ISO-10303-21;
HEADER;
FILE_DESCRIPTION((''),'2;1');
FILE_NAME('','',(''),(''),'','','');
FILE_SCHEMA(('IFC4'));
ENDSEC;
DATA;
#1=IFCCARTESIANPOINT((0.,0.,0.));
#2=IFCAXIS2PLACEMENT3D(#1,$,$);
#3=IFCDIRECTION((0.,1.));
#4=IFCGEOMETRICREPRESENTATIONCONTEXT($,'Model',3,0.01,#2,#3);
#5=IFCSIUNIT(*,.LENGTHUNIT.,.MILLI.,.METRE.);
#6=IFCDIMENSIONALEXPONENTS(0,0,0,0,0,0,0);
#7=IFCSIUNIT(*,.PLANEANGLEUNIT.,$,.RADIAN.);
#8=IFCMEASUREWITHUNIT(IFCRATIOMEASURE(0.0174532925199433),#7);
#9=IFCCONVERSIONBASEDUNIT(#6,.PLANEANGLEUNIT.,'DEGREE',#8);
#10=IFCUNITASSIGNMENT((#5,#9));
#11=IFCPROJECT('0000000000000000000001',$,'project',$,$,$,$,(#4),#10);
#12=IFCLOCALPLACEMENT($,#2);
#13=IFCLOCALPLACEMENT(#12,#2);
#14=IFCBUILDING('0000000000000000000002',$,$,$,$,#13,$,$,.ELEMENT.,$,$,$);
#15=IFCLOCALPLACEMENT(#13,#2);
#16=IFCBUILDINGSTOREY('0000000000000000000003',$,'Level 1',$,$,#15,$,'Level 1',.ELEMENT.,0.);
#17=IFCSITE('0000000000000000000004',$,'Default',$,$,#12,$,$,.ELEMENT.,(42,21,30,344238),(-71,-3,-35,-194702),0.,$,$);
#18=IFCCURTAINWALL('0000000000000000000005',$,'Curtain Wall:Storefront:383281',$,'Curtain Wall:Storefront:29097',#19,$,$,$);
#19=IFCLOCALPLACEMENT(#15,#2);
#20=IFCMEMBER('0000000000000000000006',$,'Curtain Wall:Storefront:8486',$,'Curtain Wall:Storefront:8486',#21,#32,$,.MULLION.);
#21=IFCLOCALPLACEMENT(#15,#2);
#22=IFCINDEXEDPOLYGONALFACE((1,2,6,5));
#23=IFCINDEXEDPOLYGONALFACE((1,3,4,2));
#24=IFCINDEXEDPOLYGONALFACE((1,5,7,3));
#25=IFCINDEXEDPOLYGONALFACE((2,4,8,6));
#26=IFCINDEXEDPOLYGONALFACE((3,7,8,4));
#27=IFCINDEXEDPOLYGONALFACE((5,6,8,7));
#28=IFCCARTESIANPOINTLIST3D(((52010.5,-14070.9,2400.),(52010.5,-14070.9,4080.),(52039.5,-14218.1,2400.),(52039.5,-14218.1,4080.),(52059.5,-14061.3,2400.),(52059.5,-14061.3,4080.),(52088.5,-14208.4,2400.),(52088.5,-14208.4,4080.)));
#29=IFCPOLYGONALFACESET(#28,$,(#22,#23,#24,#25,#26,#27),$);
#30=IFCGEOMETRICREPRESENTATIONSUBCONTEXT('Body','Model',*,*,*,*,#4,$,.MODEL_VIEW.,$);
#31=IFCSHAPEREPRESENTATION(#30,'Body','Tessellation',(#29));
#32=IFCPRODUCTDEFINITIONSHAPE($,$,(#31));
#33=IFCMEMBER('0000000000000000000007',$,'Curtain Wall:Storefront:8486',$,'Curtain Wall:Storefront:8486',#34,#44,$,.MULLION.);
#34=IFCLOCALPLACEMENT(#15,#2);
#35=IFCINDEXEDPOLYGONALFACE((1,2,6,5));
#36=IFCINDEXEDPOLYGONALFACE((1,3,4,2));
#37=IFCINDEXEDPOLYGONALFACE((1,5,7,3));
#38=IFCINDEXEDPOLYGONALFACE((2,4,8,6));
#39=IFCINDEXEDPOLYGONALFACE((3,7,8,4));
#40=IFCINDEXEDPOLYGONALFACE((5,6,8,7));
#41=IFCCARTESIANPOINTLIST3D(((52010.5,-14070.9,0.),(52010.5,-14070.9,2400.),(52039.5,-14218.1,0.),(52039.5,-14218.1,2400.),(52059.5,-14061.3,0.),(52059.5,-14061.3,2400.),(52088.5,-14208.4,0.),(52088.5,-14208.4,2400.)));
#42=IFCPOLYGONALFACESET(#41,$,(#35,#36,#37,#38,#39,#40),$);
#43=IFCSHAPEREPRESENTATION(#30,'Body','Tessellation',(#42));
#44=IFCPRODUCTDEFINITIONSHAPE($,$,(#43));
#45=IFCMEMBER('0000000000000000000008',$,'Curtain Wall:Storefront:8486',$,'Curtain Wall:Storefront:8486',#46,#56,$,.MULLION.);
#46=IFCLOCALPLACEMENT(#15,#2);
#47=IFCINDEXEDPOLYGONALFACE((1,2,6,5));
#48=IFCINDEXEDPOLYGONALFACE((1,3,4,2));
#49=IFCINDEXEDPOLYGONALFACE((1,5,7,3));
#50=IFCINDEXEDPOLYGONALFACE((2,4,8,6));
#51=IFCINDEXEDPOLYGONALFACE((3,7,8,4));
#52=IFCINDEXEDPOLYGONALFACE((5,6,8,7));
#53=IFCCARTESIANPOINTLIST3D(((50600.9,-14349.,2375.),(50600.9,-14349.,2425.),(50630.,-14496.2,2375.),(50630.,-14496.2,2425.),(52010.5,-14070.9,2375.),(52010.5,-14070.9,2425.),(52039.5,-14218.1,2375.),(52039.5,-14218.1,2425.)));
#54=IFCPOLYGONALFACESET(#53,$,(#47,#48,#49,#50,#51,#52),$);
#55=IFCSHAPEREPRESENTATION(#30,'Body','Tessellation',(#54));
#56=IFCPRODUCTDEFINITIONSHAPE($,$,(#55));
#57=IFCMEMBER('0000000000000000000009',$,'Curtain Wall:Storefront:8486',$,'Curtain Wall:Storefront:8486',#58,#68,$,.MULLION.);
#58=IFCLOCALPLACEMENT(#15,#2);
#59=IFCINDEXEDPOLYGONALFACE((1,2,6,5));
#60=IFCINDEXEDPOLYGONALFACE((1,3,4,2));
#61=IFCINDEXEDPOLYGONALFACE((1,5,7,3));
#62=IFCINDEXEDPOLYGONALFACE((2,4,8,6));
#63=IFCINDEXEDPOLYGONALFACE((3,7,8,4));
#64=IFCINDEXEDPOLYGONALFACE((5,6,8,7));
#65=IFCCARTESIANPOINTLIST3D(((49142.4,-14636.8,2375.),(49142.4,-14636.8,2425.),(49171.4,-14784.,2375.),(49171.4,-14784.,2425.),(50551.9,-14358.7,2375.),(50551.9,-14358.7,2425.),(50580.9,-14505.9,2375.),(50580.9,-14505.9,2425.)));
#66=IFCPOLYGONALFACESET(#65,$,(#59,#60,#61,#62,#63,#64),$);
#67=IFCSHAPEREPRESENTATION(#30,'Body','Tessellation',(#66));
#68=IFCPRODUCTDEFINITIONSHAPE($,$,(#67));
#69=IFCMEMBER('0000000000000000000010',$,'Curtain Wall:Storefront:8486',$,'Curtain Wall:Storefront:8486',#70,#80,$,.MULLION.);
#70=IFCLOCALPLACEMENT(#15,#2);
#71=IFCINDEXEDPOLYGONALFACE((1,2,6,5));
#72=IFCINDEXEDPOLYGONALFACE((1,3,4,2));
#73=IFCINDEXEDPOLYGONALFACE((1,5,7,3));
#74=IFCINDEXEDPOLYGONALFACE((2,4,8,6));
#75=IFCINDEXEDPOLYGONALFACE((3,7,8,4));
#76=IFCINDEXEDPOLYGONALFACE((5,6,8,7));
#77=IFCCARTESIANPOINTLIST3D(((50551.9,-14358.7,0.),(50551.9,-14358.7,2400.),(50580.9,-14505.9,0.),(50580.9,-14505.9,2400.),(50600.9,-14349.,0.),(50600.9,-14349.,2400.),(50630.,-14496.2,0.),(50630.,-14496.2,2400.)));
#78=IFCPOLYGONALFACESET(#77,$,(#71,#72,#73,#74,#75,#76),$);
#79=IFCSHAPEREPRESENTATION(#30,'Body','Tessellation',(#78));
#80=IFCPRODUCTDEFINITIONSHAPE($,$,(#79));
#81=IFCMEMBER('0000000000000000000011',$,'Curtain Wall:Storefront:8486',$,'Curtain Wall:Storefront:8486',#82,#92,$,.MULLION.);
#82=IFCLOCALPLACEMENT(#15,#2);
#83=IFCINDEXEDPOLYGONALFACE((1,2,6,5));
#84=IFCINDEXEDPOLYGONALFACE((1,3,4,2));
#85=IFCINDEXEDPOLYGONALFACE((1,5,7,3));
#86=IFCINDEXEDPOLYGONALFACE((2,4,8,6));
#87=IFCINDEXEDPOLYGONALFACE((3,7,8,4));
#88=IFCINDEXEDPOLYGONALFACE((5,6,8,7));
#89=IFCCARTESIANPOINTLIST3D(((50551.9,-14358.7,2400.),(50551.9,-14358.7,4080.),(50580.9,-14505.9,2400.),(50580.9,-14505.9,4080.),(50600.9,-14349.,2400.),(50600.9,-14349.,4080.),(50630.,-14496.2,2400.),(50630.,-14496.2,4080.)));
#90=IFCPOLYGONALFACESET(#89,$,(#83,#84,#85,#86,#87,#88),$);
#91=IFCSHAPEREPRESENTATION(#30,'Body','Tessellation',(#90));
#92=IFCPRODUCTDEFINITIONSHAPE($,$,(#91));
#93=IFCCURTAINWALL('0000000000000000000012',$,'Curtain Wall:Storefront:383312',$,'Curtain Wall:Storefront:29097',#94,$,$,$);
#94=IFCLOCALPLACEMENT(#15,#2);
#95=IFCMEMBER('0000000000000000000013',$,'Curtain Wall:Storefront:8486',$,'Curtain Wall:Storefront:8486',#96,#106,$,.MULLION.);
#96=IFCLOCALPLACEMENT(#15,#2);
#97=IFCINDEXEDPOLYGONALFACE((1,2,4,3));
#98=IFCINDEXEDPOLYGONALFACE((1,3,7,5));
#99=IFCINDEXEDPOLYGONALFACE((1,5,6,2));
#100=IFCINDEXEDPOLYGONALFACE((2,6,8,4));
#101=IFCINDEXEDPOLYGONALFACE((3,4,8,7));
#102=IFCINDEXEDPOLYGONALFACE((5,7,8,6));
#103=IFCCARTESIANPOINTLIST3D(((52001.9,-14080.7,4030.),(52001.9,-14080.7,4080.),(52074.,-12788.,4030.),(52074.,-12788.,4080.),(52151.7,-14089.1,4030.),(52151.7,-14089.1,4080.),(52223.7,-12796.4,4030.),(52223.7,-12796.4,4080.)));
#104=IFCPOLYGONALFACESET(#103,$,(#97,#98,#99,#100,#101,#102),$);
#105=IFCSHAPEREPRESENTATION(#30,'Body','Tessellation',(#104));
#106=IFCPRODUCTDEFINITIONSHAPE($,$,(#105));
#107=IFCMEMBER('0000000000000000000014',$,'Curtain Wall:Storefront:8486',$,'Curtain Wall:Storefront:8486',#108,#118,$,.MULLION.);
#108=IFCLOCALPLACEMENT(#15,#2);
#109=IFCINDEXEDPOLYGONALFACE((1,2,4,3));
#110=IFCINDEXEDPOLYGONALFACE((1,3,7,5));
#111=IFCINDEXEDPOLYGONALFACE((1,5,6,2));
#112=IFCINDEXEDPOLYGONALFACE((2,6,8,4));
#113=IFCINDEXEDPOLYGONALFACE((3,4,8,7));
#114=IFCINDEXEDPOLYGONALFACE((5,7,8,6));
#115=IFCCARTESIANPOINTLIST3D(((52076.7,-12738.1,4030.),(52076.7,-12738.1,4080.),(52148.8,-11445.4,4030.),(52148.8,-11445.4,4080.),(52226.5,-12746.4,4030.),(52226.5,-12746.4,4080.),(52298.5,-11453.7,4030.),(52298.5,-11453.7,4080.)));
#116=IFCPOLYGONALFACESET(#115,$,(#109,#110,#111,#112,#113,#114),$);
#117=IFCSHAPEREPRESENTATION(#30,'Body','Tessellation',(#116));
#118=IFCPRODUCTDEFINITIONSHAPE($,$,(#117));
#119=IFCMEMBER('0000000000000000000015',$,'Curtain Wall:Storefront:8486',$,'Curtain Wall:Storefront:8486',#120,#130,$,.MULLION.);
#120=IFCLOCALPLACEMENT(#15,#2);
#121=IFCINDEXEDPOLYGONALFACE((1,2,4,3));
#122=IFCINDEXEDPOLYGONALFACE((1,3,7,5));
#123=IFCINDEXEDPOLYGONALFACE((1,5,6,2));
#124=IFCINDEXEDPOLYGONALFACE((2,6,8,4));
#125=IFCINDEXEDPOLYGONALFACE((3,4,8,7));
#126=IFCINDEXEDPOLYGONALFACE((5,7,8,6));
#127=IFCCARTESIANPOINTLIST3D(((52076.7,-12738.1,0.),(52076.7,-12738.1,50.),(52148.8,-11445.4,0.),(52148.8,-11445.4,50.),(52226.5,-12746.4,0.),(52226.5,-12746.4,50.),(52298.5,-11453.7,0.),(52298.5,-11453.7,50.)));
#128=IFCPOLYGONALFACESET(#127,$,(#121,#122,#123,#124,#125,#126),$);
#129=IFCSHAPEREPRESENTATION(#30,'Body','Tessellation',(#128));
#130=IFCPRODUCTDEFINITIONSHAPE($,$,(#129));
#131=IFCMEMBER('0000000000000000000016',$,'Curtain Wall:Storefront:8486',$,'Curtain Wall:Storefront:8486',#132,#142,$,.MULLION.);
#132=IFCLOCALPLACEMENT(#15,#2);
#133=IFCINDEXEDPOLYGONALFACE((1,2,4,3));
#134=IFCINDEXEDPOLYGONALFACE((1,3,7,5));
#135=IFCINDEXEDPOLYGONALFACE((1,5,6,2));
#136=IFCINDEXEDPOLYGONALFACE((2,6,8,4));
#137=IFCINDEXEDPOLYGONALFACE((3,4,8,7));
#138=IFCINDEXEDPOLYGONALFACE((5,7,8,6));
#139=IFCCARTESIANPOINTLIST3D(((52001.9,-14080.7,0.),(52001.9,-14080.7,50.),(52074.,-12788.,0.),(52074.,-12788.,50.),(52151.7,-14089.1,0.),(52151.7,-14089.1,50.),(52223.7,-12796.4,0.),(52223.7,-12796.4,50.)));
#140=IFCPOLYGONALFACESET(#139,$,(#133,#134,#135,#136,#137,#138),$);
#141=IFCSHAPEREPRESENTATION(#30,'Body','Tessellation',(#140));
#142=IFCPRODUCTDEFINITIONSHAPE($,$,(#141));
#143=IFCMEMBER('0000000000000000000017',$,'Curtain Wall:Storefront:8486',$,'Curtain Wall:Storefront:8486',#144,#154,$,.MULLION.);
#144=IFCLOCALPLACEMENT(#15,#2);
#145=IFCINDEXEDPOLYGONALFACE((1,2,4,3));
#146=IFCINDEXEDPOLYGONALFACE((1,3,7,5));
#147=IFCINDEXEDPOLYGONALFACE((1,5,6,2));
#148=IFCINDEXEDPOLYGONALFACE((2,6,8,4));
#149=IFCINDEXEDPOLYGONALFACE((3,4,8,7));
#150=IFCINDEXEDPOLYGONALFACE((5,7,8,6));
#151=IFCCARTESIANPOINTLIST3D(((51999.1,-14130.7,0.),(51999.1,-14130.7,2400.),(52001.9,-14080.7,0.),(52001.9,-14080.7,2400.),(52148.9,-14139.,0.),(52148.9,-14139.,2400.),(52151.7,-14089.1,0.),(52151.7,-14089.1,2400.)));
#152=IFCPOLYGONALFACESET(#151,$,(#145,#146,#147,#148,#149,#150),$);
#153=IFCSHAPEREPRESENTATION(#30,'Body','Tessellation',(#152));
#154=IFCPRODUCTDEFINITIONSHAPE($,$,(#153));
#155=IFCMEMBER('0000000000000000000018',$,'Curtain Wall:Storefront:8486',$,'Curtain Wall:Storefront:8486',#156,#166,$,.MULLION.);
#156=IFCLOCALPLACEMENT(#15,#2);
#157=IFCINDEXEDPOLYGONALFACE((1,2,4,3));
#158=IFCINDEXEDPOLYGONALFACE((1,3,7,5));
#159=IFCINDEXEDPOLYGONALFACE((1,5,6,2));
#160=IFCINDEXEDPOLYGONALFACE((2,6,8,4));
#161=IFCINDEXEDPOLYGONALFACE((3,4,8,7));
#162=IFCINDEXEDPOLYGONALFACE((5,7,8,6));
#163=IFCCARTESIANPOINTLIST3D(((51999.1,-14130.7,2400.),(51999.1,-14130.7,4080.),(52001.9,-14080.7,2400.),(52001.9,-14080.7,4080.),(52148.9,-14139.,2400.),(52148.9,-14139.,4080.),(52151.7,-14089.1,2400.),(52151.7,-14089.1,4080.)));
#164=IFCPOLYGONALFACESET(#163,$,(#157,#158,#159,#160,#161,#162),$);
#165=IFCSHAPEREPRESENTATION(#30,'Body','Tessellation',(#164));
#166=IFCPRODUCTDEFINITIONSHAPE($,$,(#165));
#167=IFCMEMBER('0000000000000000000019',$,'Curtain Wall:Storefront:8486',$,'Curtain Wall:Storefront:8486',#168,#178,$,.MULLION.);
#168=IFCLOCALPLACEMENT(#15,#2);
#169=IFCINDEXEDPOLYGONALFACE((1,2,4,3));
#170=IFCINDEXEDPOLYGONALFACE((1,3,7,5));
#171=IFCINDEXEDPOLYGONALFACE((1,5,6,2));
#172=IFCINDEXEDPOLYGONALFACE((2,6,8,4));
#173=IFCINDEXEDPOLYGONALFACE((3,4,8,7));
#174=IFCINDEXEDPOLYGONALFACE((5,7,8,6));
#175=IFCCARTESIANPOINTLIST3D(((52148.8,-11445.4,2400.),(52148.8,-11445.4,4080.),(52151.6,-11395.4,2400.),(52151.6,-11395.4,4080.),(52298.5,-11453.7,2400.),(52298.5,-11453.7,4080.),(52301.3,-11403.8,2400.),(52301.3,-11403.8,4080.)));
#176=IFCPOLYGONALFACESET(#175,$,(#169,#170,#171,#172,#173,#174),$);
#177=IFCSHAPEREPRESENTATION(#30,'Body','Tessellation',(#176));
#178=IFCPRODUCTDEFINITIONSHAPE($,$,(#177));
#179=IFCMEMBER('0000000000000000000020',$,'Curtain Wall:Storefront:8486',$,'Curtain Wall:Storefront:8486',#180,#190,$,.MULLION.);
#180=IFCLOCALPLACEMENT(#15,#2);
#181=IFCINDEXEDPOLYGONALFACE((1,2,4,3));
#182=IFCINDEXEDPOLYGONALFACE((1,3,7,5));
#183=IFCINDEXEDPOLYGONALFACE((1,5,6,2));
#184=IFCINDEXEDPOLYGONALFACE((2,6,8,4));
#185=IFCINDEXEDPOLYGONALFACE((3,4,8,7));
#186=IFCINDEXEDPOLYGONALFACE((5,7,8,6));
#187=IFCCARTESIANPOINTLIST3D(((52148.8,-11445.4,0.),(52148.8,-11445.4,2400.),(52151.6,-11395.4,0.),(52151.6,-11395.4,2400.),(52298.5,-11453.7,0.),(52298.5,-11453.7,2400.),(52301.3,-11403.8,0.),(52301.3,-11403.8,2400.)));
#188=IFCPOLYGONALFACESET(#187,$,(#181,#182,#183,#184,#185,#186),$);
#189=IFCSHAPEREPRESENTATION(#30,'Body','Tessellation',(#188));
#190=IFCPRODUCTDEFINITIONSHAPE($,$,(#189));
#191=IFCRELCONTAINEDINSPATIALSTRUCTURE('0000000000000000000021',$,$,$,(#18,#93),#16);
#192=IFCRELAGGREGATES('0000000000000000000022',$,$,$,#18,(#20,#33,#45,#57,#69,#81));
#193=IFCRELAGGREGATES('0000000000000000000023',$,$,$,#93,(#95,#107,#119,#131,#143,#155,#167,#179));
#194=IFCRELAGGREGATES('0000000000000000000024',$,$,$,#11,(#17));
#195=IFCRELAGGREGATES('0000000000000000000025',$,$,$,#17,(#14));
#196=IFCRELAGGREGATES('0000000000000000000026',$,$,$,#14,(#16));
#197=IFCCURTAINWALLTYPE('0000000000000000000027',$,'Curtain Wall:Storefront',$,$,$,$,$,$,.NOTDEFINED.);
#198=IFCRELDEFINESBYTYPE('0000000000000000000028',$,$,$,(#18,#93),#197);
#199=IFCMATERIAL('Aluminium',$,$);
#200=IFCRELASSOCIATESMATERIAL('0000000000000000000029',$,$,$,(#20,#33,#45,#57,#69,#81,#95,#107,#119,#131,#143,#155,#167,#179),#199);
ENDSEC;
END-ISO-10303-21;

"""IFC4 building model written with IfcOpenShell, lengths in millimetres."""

from ifc_helpers import new_model, entity, si_unit, converted_unit, direction, frame, frame_2d, origin, origin_2d_with_axis, place, context, subcontext, project, spatial, rectangle, extrude, material, type_object, element, aggregate, save


model = new_model("IFC4")

# Units and contexts
model_context = context("Model", 3, precision=0.01, world=origin(), true_north=direction((0.0, 1.0)))
body_context = subcontext(model_context, "Body", "Model", "MODEL_VIEW")
ifc_project = project(units=[si_unit("LENGTHUNIT", "METRE", prefix="MILLI"), converted_unit("PLANEANGLEUNIT", "DEGREE", entity("IfcRatioMeasure", 0.0174532925199433), si_unit("PLANEANGLEUNIT", "RADIAN"), dimensions=[0, 0, 0, 0, 0, 0, 0])], contexts=[model_context])

# Site, building, storey
site_placement = place(None, origin())
site = spatial("IfcSite", under=ifc_project, at=site_placement, Name="Default", CompositionType="ELEMENT", RefLatitude=(42, 21, 30, 344238), RefLongitude=(-71, -3, -35, -194702), RefElevation=0.0)
building_placement = place(site_placement, origin())
building = spatial("IfcBuilding", under=site, at=building_placement, CompositionType="ELEMENT")
storey_placement = place(building_placement, origin())
storey = spatial("IfcBuildingStorey", under=building, at=storey_placement, Name="Level 1", LongName="Level 1", CompositionType="ELEMENT", Elevation=0.0)

# Curtain walls, members
curtain_wall_type = type_object("IfcCurtainWallType", Name="Curtain Wall:Storefront", PredefinedType="NOTDEFINED")
curtain_wall_1_placement = place(storey_placement, origin())
curtain_wall_1 = element("IfcCurtainWall", 1, at=curtain_wall_1_placement, inside=storey, type_object=curtain_wall_type, Name="Curtain Wall:Storefront:383281", ObjectType="Curtain Wall:Storefront:29097")
ifc_material = material(Name="Aluminium")
member_1_placement = place(curtain_wall_1_placement, origin())
member_1 = element("IfcMember", 2, at=member_1_placement, material=ifc_material, Name="Curtain Wall:Storefront:8486", ObjectType="Curtain Wall:Storefront:8486", PredefinedType="MULLION", context=body_context, shape_type="SweptSolid", body=[
    extrude(rectangle(XDim=50.0, YDim=150.0, at=frame_2d((0.0, 0.0), x_axis=(1.0, 0.0))), frame((52049.5, -14139.7, 4080.0), z_axis=(0.0, 0.0, -1.0), x_axis=(0.981087, 0.193568, 0.0)), (0.0, 0.0, 1.0), 1680.0),
])
member_2_placement = place(curtain_wall_1_placement, origin())
member_2 = element("IfcMember", 3, at=member_2_placement, material=ifc_material, Name="Curtain Wall:Storefront:8486", ObjectType="Curtain Wall:Storefront:8486", PredefinedType="MULLION", context=body_context, shape_type="SweptSolid", body=[
    extrude(rectangle(XDim=50.0, YDim=150.0, at=frame_2d((0.0, 0.0), x_axis=(1.0, 0.0))), frame((52049.5, -14139.7, 2400.0), z_axis=(0.0, 0.0, -1.0), x_axis=(0.981087, 0.193568, 0.0)), (0.0, 0.0, 1.0), 2400.0),
])
member_3_placement = place(curtain_wall_1_placement, origin())
member_3 = element("IfcMember", 4, at=member_3_placement, material=ifc_material, Name="Curtain Wall:Storefront:8486", ObjectType="Curtain Wall:Storefront:8486", PredefinedType="MULLION", context=body_context, shape_type="SweptSolid", body=[
    extrude(rectangle(XDim=50.0, YDim=150.0, at=frame_2d((0.0, 0.0), x_axis=(1.0, 0.0))), frame((50615.5, -14422.6, 2400.0), z_axis=(0.981087, 0.193568, 0.0), x_axis=(0.0, 0.0, -1.0)), (0.0, 0.0, 1.0), 1436.7),
])
member_4_placement = place(curtain_wall_1_placement, origin())
member_4 = element("IfcMember", 5, at=member_4_placement, material=ifc_material, Name="Curtain Wall:Storefront:8486", ObjectType="Curtain Wall:Storefront:8486", PredefinedType="MULLION", context=body_context, shape_type="SweptSolid", body=[
    extrude(rectangle(XDim=50.0, YDim=150.0, at=frame_2d((0.0, 0.0), x_axis=(1.0, 0.0))), frame((49156.9, -14710.4, 2400.0), z_axis=(0.981087, 0.193568, 0.0), x_axis=(0.0, 0.0, -1.0)), (0.0, 0.0, 1.0), 1436.7),
])
member_5_placement = place(curtain_wall_1_placement, origin())
member_5 = element("IfcMember", 6, at=member_5_placement, material=ifc_material, Name="Curtain Wall:Storefront:8486", ObjectType="Curtain Wall:Storefront:8486", PredefinedType="MULLION", context=body_context, shape_type="SweptSolid", body=[
    extrude(rectangle(XDim=150.0, YDim=50.0, at=origin_2d_with_axis()), frame((50590.9, -14427.5, 0.0), z_axis=(0.0, 0.0, 1.0), x_axis=(-0.193568, 0.981087, 0.0)), (0.0, 0.0, 1.0), 2400.0),
])
member_6_placement = place(curtain_wall_1_placement, origin())
member_6 = element("IfcMember", 7, at=member_6_placement, material=ifc_material, Name="Curtain Wall:Storefront:8486", ObjectType="Curtain Wall:Storefront:8486", PredefinedType="MULLION", context=body_context, shape_type="SweptSolid", body=[
    extrude(rectangle(XDim=150.0, YDim=50.0, at=origin_2d_with_axis()), frame((50590.9, -14427.5, 2400.0), z_axis=(0.0, 0.0, 1.0), x_axis=(-0.193568, 0.981087, 0.0)), (0.0, 0.0, 1.0), 1680.0),
])
aggregate(curtain_wall_1, [member_1, member_2, member_3, member_4, member_5, member_6])
curtain_wall_2_placement = place(storey_placement, origin())
curtain_wall_2 = element("IfcCurtainWall", 8, at=curtain_wall_2_placement, inside=storey, type_object=curtain_wall_type, Name="Curtain Wall:Storefront:383312", ObjectType="Curtain Wall:Storefront:29097")
member_7_placement = place(curtain_wall_2_placement, origin())
member_7 = element("IfcMember", 9, at=member_7_placement, material=ifc_material, Name="Curtain Wall:Storefront:8486", ObjectType="Curtain Wall:Storefront:8486", PredefinedType="MULLION", context=body_context, shape_type="SweptSolid", body=[
    extrude(rectangle(XDim=50.0, YDim=150.0, at=frame_2d((0.0, 0.0), x_axis=(1.0, 0.0))), frame((52076.8, -14084.9, 4055.0), z_axis=(0.055635, 0.998451, 0.0), x_axis=(0.0, 0.0, -1.0)), (0.0, 0.0, 1.0), 1294.7),
])
member_8_placement = place(curtain_wall_2_placement, origin())
member_8 = element("IfcMember", 10, at=member_8_placement, material=ifc_material, Name="Curtain Wall:Storefront:8486", ObjectType="Curtain Wall:Storefront:8486", PredefinedType="MULLION", context=body_context, shape_type="SweptSolid", body=[
    extrude(rectangle(XDim=50.0, YDim=150.0, at=frame_2d((0.0, 0.0), x_axis=(1.0, 0.0))), frame((52151.6, -12742.3, 4055.0), z_axis=(0.055635, 0.998451, 0.0), x_axis=(0.0, 0.0, -1.0)), (0.0, 0.0, 1.0), 1294.7),
])
member_9_placement = place(curtain_wall_2_placement, origin())
member_9 = element("IfcMember", 11, at=member_9_placement, material=ifc_material, Name="Curtain Wall:Storefront:8486", ObjectType="Curtain Wall:Storefront:8486", PredefinedType="MULLION", context=body_context, shape_type="SweptSolid", body=[
    extrude(rectangle(XDim=50.0, YDim=150.0, at=origin_2d_with_axis()), frame((52223.7, -11449.5, 25.0), z_axis=(-0.055635, -0.998451, 0.0), x_axis=(0.0, 0.0, -1.0)), (0.0, 0.0, 1.0), 1294.7),
])
member_10_placement = place(curtain_wall_2_placement, origin())
member_10 = element("IfcMember", 12, at=member_10_placement, material=ifc_material, Name="Curtain Wall:Storefront:8486", ObjectType="Curtain Wall:Storefront:8486", PredefinedType="MULLION", context=body_context, shape_type="SweptSolid", body=[
    extrude(rectangle(XDim=50.0, YDim=150.0, at=frame_2d((0.0, 0.0), x_axis=(1.0, 0.0))), frame((52148.8, -12792.2, 25.0), z_axis=(-0.055635, -0.998451, 0.0), x_axis=(0.0, 0.0, -1.0)), (0.0, 0.0, 1.0), 1294.7),
])
member_11_placement = place(curtain_wall_2_placement, origin())
member_11 = element("IfcMember", 13, at=member_11_placement, material=ifc_material, Name="Curtain Wall:Storefront:8486", ObjectType="Curtain Wall:Storefront:8486", PredefinedType="MULLION", context=body_context, shape_type="SweptSolid", body=[
    extrude(rectangle(XDim=150.0, YDim=50.0, at=frame_2d((0.0, 0.0), x_axis=(1.0, 0.0))), frame((52075.4, -14109.9, 0.0), z_axis=(0.0, 0.0, 1.0), x_axis=(0.998451, -0.055635, 0.0)), (0.0, 0.0, 1.0), 2400.0),
])
member_12_placement = place(curtain_wall_2_placement, origin())
member_12 = element("IfcMember", 14, at=member_12_placement, material=ifc_material, Name="Curtain Wall:Storefront:8486", ObjectType="Curtain Wall:Storefront:8486", PredefinedType="MULLION", context=body_context, shape_type="SweptSolid", body=[
    extrude(rectangle(XDim=150.0, YDim=50.0, at=frame_2d((0.0, 0.0), x_axis=(1.0, 0.0))), frame((52075.4, -14109.9, 2400.0), z_axis=(0.0, 0.0, 1.0), x_axis=(0.998451, -0.055635, 0.0)), (0.0, 0.0, 1.0), 1680.0),
])
member_13_placement = place(curtain_wall_2_placement, origin())
member_13 = element("IfcMember", 15, at=member_13_placement, material=ifc_material, Name="Curtain Wall:Storefront:8486", ObjectType="Curtain Wall:Storefront:8486", PredefinedType="MULLION", context=body_context, shape_type="SweptSolid", body=[
    extrude(rectangle(XDim=150.0, YDim=50.0, at=frame_2d((0.0, 0.0), x_axis=(1.0, 0.0))), frame((52225.0, -11424.6, 4080.0), z_axis=(0.0, 0.0, -1.0), x_axis=(0.998451, -0.055635, 0.0)), (0.0, 0.0, 1.0), 1680.0),
])
member_14_placement = place(curtain_wall_2_placement, origin())
member_14 = element("IfcMember", 16, at=member_14_placement, material=ifc_material, Name="Curtain Wall:Storefront:8486", ObjectType="Curtain Wall:Storefront:8486", PredefinedType="MULLION", context=body_context, shape_type="SweptSolid", body=[
    extrude(rectangle(XDim=150.0, YDim=50.0, at=frame_2d((0.0, 0.0), x_axis=(1.0, 0.0))), frame((52225.0, -11424.6, 2400.0), z_axis=(0.0, 0.0, -1.0), x_axis=(0.998451, -0.055635, 0.0)), (0.0, 0.0, 1.0), 2400.0),
])
aggregate(curtain_wall_2, [member_7, member_8, member_9, member_10, member_11, member_12, member_13, member_14])

save(model, "model.ifc")
